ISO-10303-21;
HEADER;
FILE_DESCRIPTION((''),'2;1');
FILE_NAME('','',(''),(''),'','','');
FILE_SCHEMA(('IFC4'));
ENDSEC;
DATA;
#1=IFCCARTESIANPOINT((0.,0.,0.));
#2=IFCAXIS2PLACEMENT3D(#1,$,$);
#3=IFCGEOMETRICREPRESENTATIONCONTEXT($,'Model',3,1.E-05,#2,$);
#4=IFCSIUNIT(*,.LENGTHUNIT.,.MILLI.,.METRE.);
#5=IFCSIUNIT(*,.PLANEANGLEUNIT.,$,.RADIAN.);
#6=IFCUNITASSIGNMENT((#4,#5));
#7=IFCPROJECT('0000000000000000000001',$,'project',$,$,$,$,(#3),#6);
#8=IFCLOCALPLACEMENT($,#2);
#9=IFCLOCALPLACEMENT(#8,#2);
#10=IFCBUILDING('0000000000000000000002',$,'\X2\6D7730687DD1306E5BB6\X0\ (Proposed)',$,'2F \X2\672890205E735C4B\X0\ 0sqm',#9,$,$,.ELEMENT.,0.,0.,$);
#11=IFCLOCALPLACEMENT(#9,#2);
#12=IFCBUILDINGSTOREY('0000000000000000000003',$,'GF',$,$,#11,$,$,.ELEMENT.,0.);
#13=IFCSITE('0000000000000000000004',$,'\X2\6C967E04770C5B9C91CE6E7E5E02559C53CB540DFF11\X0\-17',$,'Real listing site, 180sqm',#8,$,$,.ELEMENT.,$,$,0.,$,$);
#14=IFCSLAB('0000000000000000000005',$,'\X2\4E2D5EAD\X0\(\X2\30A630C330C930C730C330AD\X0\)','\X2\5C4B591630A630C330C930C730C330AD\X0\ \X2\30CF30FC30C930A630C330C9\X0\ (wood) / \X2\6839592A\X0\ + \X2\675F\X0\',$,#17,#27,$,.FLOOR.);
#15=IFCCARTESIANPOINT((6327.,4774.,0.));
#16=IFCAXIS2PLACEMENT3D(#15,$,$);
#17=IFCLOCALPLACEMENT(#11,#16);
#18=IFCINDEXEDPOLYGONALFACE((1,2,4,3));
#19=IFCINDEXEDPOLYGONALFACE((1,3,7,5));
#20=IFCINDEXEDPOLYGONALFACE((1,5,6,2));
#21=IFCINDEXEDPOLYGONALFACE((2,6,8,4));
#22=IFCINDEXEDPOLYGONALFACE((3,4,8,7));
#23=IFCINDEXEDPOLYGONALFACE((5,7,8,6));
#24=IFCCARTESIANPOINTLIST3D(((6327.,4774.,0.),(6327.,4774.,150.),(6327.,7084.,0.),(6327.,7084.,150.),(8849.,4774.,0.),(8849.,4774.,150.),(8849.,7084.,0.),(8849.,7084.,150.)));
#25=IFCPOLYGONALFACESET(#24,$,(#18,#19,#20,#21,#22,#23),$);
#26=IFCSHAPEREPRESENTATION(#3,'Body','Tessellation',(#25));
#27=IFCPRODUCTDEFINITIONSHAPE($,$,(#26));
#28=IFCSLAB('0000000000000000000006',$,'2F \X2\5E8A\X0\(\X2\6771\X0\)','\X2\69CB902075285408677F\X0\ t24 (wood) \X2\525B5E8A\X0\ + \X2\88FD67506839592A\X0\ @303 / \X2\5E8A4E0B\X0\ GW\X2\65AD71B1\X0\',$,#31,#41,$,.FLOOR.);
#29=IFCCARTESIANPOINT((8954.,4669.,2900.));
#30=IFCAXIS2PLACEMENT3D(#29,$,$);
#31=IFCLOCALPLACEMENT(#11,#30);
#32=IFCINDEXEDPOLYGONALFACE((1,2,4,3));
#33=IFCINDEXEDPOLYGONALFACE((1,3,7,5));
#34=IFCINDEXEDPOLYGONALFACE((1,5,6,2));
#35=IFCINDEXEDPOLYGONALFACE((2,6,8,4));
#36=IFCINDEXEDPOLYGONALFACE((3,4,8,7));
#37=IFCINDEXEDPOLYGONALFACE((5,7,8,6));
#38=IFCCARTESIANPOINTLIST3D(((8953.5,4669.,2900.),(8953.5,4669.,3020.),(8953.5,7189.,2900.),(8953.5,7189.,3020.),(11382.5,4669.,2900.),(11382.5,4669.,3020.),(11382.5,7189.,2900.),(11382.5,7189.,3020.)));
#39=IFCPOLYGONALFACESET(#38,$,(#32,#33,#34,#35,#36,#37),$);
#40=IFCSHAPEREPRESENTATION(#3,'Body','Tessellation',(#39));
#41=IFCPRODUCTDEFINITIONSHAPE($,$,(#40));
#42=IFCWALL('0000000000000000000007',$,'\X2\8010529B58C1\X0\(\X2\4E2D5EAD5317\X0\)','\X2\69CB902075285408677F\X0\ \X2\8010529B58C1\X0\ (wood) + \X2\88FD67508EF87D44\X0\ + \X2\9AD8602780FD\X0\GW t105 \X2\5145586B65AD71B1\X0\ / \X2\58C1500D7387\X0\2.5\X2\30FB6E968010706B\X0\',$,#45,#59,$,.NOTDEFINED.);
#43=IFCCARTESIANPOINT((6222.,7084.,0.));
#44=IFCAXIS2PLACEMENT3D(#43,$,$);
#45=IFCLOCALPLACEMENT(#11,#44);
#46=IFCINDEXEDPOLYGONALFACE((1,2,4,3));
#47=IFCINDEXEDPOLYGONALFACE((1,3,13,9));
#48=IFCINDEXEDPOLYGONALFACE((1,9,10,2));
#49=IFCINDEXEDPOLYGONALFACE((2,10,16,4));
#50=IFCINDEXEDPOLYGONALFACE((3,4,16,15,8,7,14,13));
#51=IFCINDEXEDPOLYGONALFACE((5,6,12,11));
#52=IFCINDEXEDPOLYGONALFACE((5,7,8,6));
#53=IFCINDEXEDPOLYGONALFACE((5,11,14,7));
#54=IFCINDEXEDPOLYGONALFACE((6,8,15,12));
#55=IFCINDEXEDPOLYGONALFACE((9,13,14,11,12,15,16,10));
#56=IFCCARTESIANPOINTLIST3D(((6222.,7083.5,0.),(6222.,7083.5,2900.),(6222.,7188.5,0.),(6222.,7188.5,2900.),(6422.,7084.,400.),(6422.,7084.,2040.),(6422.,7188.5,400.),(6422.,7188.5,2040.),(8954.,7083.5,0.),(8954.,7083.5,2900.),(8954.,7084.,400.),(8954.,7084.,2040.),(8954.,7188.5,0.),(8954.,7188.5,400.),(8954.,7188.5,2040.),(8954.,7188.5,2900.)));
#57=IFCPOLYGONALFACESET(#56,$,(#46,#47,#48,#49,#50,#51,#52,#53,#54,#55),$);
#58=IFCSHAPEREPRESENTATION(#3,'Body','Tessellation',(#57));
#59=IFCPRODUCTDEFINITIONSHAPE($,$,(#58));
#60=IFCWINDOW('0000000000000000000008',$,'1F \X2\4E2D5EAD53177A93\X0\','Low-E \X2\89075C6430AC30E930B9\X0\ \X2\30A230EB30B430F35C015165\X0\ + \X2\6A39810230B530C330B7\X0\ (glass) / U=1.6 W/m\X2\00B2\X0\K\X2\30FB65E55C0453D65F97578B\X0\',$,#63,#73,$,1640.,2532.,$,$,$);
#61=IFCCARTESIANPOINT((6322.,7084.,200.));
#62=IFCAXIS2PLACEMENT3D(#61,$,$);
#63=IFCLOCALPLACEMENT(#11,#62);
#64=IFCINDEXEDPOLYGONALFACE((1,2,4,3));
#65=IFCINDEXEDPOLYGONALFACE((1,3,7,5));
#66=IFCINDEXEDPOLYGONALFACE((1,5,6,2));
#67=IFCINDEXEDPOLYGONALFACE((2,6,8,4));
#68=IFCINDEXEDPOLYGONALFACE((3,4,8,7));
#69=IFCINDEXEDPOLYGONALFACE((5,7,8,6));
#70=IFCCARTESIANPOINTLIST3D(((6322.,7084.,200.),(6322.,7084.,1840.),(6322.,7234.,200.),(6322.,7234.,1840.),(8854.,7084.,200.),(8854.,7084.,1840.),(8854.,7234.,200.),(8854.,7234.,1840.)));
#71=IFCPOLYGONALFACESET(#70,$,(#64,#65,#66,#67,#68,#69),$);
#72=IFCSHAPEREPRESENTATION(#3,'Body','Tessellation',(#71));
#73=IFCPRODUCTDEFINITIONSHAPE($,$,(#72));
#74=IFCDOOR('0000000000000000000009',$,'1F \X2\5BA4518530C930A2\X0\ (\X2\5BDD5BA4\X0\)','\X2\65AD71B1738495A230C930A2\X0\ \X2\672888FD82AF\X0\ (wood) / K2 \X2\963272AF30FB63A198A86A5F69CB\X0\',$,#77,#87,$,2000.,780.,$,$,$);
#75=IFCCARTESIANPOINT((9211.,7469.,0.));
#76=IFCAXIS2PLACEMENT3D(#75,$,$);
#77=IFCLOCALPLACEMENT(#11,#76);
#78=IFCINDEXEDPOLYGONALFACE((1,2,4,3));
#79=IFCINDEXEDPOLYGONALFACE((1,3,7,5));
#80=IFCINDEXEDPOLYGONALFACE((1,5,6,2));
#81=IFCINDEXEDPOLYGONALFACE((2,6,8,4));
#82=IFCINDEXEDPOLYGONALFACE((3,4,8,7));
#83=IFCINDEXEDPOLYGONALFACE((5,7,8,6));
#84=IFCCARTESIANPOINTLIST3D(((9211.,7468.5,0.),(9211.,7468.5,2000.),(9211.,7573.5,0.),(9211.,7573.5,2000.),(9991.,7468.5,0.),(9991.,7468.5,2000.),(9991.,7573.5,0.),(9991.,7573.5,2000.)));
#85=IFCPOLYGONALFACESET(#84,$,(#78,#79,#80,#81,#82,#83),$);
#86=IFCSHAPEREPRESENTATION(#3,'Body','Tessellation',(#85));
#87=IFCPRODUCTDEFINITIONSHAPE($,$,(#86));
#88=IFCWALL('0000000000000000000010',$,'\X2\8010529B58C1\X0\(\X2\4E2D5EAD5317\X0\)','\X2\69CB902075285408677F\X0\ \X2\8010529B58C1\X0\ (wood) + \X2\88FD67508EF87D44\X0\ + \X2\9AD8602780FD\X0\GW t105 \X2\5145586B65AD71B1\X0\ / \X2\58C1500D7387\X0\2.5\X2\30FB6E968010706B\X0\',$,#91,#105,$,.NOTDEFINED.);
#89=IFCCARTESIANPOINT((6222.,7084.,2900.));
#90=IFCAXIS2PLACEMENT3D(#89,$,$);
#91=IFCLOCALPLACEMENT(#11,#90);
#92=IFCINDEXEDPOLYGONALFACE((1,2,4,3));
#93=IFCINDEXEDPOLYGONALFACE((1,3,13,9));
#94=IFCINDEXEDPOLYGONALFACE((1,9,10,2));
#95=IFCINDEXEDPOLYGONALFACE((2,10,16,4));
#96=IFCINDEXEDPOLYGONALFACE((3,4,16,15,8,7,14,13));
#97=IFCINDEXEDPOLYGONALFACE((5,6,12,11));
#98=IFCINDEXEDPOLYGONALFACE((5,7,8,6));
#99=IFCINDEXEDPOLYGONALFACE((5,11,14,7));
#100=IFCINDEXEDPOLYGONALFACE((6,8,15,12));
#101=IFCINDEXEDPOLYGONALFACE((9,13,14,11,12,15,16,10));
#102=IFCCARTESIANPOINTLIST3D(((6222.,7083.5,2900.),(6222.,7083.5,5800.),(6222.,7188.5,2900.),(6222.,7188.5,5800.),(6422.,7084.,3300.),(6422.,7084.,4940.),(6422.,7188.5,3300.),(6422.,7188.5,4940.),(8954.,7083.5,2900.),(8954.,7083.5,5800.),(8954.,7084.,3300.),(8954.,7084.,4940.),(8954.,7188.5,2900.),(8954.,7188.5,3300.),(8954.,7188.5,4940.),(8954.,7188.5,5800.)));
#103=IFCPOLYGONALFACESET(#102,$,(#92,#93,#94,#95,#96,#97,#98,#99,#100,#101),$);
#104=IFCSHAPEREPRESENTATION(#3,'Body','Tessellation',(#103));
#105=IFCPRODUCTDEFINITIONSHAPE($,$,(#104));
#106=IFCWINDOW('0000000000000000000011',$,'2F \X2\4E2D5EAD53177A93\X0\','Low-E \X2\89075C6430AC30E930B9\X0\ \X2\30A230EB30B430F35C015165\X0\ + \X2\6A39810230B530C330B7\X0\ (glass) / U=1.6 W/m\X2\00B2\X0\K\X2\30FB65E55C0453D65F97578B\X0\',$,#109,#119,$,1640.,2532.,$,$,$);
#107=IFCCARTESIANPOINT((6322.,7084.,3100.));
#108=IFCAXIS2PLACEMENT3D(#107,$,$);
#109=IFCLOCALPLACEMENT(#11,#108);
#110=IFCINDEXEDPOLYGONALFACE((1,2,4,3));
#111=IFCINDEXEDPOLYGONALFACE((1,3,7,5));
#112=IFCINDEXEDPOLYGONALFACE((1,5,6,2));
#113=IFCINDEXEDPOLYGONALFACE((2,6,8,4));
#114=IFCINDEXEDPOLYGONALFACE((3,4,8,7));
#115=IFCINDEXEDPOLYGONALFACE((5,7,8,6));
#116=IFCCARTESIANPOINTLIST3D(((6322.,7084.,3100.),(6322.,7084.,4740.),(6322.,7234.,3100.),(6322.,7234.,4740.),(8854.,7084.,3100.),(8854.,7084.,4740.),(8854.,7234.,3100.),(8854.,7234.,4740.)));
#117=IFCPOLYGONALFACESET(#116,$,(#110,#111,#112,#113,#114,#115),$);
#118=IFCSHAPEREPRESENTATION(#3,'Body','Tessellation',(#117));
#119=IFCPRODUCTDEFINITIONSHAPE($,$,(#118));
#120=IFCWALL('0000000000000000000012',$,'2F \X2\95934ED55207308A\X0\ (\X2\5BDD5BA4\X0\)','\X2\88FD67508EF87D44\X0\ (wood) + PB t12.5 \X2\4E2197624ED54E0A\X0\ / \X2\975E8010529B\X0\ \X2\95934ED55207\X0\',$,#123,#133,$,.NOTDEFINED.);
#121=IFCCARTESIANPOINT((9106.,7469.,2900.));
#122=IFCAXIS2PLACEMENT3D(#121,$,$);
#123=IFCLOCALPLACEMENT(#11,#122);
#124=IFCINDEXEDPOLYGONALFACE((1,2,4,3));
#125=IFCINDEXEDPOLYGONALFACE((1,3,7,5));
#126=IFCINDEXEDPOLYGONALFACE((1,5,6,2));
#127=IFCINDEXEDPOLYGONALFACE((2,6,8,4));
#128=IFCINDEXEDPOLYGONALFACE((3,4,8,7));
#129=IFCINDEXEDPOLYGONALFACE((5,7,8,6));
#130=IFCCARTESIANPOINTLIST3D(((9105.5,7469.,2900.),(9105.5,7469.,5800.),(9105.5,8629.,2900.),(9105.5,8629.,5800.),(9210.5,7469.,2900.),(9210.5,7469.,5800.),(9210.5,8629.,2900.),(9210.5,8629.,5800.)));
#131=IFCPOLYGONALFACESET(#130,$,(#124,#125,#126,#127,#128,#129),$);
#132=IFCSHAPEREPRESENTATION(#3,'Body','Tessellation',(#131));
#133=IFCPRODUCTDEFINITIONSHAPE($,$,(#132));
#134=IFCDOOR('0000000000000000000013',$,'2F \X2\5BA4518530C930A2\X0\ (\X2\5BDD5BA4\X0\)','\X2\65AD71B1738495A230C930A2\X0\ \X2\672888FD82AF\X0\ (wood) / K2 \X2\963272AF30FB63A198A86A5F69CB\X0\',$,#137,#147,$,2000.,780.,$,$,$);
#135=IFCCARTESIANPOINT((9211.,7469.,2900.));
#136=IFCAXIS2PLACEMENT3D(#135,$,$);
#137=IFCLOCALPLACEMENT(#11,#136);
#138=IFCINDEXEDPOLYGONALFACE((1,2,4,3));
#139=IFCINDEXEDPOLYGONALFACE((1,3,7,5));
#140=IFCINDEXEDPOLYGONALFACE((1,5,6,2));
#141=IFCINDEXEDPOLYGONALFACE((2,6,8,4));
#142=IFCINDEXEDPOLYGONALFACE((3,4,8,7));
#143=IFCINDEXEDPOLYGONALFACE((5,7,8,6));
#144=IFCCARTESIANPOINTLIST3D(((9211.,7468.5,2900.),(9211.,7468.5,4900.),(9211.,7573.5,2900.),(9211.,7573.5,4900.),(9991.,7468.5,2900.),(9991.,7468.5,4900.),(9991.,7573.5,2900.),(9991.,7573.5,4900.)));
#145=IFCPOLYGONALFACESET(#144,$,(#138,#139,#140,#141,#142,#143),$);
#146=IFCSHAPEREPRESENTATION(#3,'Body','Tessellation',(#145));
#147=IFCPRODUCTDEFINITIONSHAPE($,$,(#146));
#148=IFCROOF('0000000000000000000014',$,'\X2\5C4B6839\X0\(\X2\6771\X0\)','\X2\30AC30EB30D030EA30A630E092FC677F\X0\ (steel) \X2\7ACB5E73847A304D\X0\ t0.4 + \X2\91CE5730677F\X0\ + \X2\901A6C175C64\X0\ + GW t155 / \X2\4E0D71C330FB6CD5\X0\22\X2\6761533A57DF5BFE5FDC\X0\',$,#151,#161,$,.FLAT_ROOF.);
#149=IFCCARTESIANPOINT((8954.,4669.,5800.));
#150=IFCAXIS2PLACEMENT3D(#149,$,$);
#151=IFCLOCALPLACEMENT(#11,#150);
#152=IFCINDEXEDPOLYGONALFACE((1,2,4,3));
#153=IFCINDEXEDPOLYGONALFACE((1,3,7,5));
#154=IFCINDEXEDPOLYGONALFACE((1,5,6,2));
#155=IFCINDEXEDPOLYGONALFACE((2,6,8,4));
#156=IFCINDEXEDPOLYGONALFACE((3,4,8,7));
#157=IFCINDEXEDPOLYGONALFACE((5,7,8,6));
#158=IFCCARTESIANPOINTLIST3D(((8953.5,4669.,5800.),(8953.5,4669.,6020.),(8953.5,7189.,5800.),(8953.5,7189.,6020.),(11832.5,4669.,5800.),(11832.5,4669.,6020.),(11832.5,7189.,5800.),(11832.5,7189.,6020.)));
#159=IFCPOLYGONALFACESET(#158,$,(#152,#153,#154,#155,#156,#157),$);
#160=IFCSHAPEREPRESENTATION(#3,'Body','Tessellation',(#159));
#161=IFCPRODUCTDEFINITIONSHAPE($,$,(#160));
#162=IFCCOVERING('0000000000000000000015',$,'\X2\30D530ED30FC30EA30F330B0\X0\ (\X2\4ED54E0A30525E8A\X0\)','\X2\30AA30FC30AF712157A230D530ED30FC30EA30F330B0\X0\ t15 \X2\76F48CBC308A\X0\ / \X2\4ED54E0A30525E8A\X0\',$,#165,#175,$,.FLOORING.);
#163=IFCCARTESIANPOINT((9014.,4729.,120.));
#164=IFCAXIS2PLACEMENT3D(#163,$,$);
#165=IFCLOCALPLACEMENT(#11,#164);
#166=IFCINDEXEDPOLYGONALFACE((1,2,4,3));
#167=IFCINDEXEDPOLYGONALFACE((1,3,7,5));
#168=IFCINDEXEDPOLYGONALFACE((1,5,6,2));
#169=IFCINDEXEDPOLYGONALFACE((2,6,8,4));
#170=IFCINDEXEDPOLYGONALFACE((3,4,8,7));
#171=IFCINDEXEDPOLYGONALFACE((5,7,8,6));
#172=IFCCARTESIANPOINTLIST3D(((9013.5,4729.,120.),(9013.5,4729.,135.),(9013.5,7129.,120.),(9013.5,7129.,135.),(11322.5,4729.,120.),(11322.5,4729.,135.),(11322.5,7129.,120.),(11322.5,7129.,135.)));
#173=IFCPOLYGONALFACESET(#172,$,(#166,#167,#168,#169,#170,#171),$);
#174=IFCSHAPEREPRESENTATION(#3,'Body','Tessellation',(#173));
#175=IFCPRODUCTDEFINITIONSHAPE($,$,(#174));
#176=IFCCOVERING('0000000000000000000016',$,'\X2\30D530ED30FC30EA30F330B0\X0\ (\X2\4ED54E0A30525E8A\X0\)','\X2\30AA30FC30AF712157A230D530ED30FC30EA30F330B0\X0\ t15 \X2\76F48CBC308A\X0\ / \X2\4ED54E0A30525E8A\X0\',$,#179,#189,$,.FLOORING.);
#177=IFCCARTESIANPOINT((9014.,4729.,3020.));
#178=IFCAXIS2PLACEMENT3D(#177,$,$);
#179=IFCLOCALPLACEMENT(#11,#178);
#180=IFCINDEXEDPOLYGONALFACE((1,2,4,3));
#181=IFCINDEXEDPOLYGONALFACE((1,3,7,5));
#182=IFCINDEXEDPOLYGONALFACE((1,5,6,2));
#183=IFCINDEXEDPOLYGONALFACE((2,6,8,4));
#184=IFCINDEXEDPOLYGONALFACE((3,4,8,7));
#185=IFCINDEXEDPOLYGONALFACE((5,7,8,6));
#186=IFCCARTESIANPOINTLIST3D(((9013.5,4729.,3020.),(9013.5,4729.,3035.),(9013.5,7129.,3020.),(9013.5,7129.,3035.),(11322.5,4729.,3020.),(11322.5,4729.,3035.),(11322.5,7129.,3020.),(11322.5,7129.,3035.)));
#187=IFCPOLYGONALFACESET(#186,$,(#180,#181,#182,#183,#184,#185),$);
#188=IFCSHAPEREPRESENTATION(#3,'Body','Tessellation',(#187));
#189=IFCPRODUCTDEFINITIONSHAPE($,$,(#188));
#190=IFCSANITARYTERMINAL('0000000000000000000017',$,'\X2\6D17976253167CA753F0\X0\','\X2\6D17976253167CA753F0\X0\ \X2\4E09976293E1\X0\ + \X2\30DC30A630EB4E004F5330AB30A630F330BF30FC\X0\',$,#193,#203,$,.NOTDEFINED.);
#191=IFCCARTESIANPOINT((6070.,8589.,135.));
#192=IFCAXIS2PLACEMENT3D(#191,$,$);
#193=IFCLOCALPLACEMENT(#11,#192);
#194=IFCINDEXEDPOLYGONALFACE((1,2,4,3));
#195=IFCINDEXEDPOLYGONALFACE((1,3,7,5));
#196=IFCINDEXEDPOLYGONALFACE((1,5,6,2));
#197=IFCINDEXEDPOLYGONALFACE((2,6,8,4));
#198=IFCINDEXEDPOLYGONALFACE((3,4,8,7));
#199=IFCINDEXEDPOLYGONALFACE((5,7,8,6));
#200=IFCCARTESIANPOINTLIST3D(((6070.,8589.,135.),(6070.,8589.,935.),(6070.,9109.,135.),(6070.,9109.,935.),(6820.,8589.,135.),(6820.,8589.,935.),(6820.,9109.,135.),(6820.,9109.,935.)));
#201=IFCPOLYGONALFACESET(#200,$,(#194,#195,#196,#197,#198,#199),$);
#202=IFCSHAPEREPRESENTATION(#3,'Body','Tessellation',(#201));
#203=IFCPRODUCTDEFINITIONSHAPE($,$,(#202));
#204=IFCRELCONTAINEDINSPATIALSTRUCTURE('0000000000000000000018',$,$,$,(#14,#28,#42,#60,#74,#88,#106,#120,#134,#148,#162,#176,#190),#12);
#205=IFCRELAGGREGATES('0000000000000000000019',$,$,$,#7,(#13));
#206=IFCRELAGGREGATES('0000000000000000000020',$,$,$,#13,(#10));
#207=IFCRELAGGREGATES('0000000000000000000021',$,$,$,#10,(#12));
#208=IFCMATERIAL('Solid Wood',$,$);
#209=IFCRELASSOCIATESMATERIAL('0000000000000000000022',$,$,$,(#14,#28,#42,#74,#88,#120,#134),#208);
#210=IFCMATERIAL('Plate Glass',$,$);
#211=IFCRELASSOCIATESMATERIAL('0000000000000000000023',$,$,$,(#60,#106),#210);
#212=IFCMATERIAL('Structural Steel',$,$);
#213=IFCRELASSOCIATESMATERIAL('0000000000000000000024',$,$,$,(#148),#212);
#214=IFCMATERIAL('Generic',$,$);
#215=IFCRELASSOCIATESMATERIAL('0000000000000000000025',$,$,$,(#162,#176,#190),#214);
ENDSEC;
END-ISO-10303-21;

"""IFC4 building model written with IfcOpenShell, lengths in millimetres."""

from ifc_helpers import new_model, si_unit, frame, frame_2d, origin, place, context, project, spatial, rectangle, extrude, material, element, fill, save


model = new_model("IFC4")

# Units and contexts
model_context = context("Model", 3, precision=1e-05, world=origin())
ifc_project = project(units=[si_unit("LENGTHUNIT", "METRE", prefix="MILLI"), si_unit("PLANEANGLEUNIT", "RADIAN")], contexts=[model_context])

# Site, building, storey
site_placement = place(None, origin())
site = spatial("IfcSite", under=ifc_project, at=site_placement, Name="沖縄県宜野湾市喜友名１-17", ObjectType="Real listing site, 180sqm", CompositionType="ELEMENT", RefElevation=0.0)
building_placement = place(site_placement, origin())
building = spatial("IfcBuilding", under=site, at=building_placement, Name="海と緑の家 (Proposed)", ObjectType="2F 木造平屋 0sqm", CompositionType="ELEMENT", ElevationOfRefHeight=0.0, ElevationOfTerrain=0.0)
storey_placement = place(building_placement, origin())
storey = spatial("IfcBuildingStorey", under=building, at=storey_placement, Name="GF", CompositionType="ELEMENT", Elevation=0.0)

# Slabs
ifc_material_1 = material(Name="Solid Wood")
slab_1_placement = place(storey_placement, frame((6327.0, 4774.0, 0.0)))
element("IfcSlab", 1, at=slab_1_placement, inside=storey, material=ifc_material_1, Name="中庭(ウッドデッキ)", Description="屋外ウッドデッキ ハードウッド (wood) / 根太 + 束", PredefinedType="FLOOR", context=model_context, shape_type="SweptSolid", body=[
    extrude(rectangle(XDim=2522.0, YDim=2310.0, at=frame_2d((1261.0, 1155.0))), frame((6327.0, 4774.0, 0.0)), (0.0, 0.0, 1.0), 150.0),
])
slab_2_placement = place(storey_placement, frame((8954.0, 4669.0, 2900.0)))
element("IfcSlab", 2, at=slab_2_placement, inside=storey, material=ifc_material_1, Name="2F 床(東)", Description="構造用合板 t24 (wood) 剛床 + 製材根太 @303 / 床下 GW断熱", PredefinedType="FLOOR", context=model_context, shape_type="SweptSolid", body=[
    extrude(rectangle(XDim=2429.0, YDim=2520.0, at=frame_2d((1214.0, 1260.0))), frame((8954.0, 4669.0, 2900.0)), (0.0, 0.0, 1.0), 120.0),
])

# Wall, opening, window
wall_1_placement = place(storey_placement, frame((6222.0, 7084.0, 0.0)))
wall_1 = element("IfcWall", 3, at=wall_1_placement, inside=storey, material=ifc_material_1, Name="耐力壁(中庭北)", Description="構造用合板 耐力壁 (wood) + 製材軸組 + 高性能GW t105 充填断熱 / 壁倍率2.5・準耐火", PredefinedType="NOTDEFINED", context=model_context, shape_type="SweptSolid", body=[
    extrude(rectangle(XDim=2732.0, YDim=105.0, at=frame_2d((1366.0, 52.0))), frame((6222.0, 7084.0, 0.0)), (0.0, 0.0, 1.0), 2900.0),
])
opening_1_placement = place(storey_placement, frame((6322.0, 7084.0, 200.0)))
opening_1 = element("IfcOpeningElement", 4, at=opening_1_placement, cuts=wall_1, PredefinedType="NOTDEFINED", context=model_context, shape_type="SweptSolid", body=[
    extrude(rectangle(XDim=2532.0, YDim=150.0, at=frame_2d((1266.0, 75.0))), frame((6322.0, 7084.0, 200.0)), (0.0, 0.0, 1.0), 1640.0),
])
ifc_material_2 = material(Name="Plate Glass")
window_1_placement = place(storey_placement, frame((6322.0, 7084.0, 200.0)))
window_1 = element("IfcWindow", 5, at=window_1_placement, inside=storey, material=ifc_material_2, Name="1F 中庭北窓", Description="Low-E 複層ガラス アルゴン封入 + 樹脂サッシ (glass) / U=1.6 W/m²K・日射取得型", OverallHeight=1640.0, OverallWidth=2532.0, context=model_context, shape_type="SweptSolid", body=[
    extrude(rectangle(XDim=2532.0, YDim=150.0, at=frame_2d((1266.0, 75.0))), frame((6322.0, 7084.0, 200.0)), (0.0, 0.0, 1.0), 1640.0),
])
fill(opening_1, window_1)

# Door
door_1_placement = place(storey_placement, frame((9211.0, 7469.0, 0.0)))
element("IfcDoor", 6, at=door_1_placement, inside=storey, material=ifc_material_1, Name="1F 室内ドア (寝室)", Description="断熱玄関ドア 木製芯 (wood) / K2 防犯・採風機構", OverallHeight=2000.0, OverallWidth=780.0, context=model_context, shape_type="SweptSolid", body=[
    extrude(rectangle(XDim=780.0, YDim=105.0, at=frame_2d((390.0, 52.0))), frame((9211.0, 7469.0, 0.0)), (0.0, 0.0, 1.0), 2000.0),
])

# Wall, opening, window
wall_2_placement = place(storey_placement, frame((6222.0, 7084.0, 2900.0)))
wall_2 = element("IfcWall", 7, at=wall_2_placement, inside=storey, material=ifc_material_1, Name="耐力壁(中庭北)", Description="構造用合板 耐力壁 (wood) + 製材軸組 + 高性能GW t105 充填断熱 / 壁倍率2.5・準耐火", PredefinedType="NOTDEFINED", context=model_context, shape_type="SweptSolid", body=[
    extrude(rectangle(XDim=2732.0, YDim=105.0, at=frame_2d((1366.0, 52.0))), frame((6222.0, 7084.0, 2900.0)), (0.0, 0.0, 1.0), 2900.0),
])
opening_2_placement = place(storey_placement, frame((6322.0, 7084.0, 3100.0)))
opening_2 = element("IfcOpeningElement", 8, at=opening_2_placement, cuts=wall_2, PredefinedType="NOTDEFINED", context=model_context, shape_type="SweptSolid", body=[
    extrude(rectangle(XDim=2532.0, YDim=150.0, at=frame_2d((1266.0, 75.0))), frame((6322.0, 7084.0, 3100.0)), (0.0, 0.0, 1.0), 1640.0),
])
window_2_placement = place(storey_placement, frame((6322.0, 7084.0, 3100.0)))
window_2 = element("IfcWindow", 9, at=window_2_placement, inside=storey, material=ifc_material_2, Name="2F 中庭北窓", Description="Low-E 複層ガラス アルゴン封入 + 樹脂サッシ (glass) / U=1.6 W/m²K・日射取得型", OverallHeight=1640.0, OverallWidth=2532.0, context=model_context, shape_type="SweptSolid", body=[
    extrude(rectangle(XDim=2532.0, YDim=150.0, at=frame_2d((1266.0, 75.0))), frame((6322.0, 7084.0, 3100.0)), (0.0, 0.0, 1.0), 1640.0),
])
fill(opening_2, window_2)

# Wall
wall_3_placement = place(storey_placement, frame((9106.0, 7469.0, 2900.0)))
element("IfcWall", 10, at=wall_3_placement, inside=storey, material=ifc_material_1, Name="2F 間仕切り (寝室)", Description="製材軸組 (wood) + PB t12.5 両面仕上 / 非耐力 間仕切", PredefinedType="NOTDEFINED", context=model_context, shape_type="SweptSolid", body=[
    extrude(rectangle(XDim=105.0, YDim=1160.0, at=frame_2d((52.0, 580.0))), frame((9106.0, 7469.0, 2900.0)), (0.0, 0.0, 1.0), 2900.0),
])

# Door
door_2_placement = place(storey_placement, frame((9211.0, 7469.0, 2900.0)))
element("IfcDoor", 11, at=door_2_placement, inside=storey, material=ifc_material_1, Name="2F 室内ドア (寝室)", Description="断熱玄関ドア 木製芯 (wood) / K2 防犯・採風機構", OverallHeight=2000.0, OverallWidth=780.0, context=model_context, shape_type="SweptSolid", body=[
    extrude(rectangle(XDim=780.0, YDim=105.0, at=frame_2d((390.0, 52.0))), frame((9211.0, 7469.0, 2900.0)), (0.0, 0.0, 1.0), 2000.0),
])

# Roof
ifc_material_3 = material(Name="Structural Steel")
for number, where, name in (
    (12, (8954.0, 4669.0, 5800.0), "屋根(東)"),
):
    element("IfcRoof", number, at=place(storey_placement, frame(where)), inside=storey, material=ifc_material_3, Name=name, Description="ガルバリウム鋼板 (steel) 立平葺き t0.4 + 野地板 + 通気層 + GW t155 / 不燃・法22条区域対応", PredefinedType="FLAT_ROOF", context=model_context, shape_type="SweptSolid", body=[
        extrude(rectangle(XDim=2879.0, YDim=2520.0, at=frame_2d((1439.0, 1260.0))), frame((8954.0, 4669.0, 5800.0)), (0.0, 0.0, 1.0), 220.0),
    ])

# Coverings
ifc_material_4 = material(Name="Generic")
covering_1_placement = place(storey_placement, frame((9014.0, 4729.0, 120.0)))
element("IfcCovering", 13, at=covering_1_placement, inside=storey, material=ifc_material_4, Name="フローリング (仕上げ床)", Description="オーク無垢フローリング t15 直貼り / 仕上げ床", PredefinedType="FLOORING", context=model_context, shape_type="SweptSolid", body=[
    extrude(rectangle(XDim=2309.0, YDim=2400.0, at=frame_2d((1154.0, 1200.0))), frame((9014.0, 4729.0, 120.0)), (0.0, 0.0, 1.0), 15.0),
])
covering_2_placement = place(storey_placement, frame((9014.0, 4729.0, 3020.0)))
element("IfcCovering", 14, at=covering_2_placement, inside=storey, material=ifc_material_4, Name="フローリング (仕上げ床)", Description="オーク無垢フローリング t15 直貼り / 仕上げ床", PredefinedType="FLOORING", context=model_context, shape_type="SweptSolid", body=[
    extrude(rectangle(XDim=2309.0, YDim=2400.0, at=frame_2d((1154.0, 1200.0))), frame((9014.0, 4729.0, 3020.0)), (0.0, 0.0, 1.0), 15.0),
])

# Sanitary terminal
sanitary_terminal_1_placement = place(storey_placement, frame((6070.0, 8589.0, 135.0)))
element("IfcSanitaryTerminal", 15, at=sanitary_terminal_1_placement, inside=storey, material=ifc_material_4, Name="洗面化粧台", Description="洗面化粧台 三面鏡 + ボウル一体カウンター", PredefinedType="NOTDEFINED", context=model_context, shape_type="SweptSolid", body=[
    extrude(rectangle(XDim=750.0, YDim=520.0, at=frame_2d((375.0, 260.0))), frame((6070.0, 8589.0, 135.0)), (0.0, 0.0, 1.0), 800.0),
])

save(model, "model.ifc")
